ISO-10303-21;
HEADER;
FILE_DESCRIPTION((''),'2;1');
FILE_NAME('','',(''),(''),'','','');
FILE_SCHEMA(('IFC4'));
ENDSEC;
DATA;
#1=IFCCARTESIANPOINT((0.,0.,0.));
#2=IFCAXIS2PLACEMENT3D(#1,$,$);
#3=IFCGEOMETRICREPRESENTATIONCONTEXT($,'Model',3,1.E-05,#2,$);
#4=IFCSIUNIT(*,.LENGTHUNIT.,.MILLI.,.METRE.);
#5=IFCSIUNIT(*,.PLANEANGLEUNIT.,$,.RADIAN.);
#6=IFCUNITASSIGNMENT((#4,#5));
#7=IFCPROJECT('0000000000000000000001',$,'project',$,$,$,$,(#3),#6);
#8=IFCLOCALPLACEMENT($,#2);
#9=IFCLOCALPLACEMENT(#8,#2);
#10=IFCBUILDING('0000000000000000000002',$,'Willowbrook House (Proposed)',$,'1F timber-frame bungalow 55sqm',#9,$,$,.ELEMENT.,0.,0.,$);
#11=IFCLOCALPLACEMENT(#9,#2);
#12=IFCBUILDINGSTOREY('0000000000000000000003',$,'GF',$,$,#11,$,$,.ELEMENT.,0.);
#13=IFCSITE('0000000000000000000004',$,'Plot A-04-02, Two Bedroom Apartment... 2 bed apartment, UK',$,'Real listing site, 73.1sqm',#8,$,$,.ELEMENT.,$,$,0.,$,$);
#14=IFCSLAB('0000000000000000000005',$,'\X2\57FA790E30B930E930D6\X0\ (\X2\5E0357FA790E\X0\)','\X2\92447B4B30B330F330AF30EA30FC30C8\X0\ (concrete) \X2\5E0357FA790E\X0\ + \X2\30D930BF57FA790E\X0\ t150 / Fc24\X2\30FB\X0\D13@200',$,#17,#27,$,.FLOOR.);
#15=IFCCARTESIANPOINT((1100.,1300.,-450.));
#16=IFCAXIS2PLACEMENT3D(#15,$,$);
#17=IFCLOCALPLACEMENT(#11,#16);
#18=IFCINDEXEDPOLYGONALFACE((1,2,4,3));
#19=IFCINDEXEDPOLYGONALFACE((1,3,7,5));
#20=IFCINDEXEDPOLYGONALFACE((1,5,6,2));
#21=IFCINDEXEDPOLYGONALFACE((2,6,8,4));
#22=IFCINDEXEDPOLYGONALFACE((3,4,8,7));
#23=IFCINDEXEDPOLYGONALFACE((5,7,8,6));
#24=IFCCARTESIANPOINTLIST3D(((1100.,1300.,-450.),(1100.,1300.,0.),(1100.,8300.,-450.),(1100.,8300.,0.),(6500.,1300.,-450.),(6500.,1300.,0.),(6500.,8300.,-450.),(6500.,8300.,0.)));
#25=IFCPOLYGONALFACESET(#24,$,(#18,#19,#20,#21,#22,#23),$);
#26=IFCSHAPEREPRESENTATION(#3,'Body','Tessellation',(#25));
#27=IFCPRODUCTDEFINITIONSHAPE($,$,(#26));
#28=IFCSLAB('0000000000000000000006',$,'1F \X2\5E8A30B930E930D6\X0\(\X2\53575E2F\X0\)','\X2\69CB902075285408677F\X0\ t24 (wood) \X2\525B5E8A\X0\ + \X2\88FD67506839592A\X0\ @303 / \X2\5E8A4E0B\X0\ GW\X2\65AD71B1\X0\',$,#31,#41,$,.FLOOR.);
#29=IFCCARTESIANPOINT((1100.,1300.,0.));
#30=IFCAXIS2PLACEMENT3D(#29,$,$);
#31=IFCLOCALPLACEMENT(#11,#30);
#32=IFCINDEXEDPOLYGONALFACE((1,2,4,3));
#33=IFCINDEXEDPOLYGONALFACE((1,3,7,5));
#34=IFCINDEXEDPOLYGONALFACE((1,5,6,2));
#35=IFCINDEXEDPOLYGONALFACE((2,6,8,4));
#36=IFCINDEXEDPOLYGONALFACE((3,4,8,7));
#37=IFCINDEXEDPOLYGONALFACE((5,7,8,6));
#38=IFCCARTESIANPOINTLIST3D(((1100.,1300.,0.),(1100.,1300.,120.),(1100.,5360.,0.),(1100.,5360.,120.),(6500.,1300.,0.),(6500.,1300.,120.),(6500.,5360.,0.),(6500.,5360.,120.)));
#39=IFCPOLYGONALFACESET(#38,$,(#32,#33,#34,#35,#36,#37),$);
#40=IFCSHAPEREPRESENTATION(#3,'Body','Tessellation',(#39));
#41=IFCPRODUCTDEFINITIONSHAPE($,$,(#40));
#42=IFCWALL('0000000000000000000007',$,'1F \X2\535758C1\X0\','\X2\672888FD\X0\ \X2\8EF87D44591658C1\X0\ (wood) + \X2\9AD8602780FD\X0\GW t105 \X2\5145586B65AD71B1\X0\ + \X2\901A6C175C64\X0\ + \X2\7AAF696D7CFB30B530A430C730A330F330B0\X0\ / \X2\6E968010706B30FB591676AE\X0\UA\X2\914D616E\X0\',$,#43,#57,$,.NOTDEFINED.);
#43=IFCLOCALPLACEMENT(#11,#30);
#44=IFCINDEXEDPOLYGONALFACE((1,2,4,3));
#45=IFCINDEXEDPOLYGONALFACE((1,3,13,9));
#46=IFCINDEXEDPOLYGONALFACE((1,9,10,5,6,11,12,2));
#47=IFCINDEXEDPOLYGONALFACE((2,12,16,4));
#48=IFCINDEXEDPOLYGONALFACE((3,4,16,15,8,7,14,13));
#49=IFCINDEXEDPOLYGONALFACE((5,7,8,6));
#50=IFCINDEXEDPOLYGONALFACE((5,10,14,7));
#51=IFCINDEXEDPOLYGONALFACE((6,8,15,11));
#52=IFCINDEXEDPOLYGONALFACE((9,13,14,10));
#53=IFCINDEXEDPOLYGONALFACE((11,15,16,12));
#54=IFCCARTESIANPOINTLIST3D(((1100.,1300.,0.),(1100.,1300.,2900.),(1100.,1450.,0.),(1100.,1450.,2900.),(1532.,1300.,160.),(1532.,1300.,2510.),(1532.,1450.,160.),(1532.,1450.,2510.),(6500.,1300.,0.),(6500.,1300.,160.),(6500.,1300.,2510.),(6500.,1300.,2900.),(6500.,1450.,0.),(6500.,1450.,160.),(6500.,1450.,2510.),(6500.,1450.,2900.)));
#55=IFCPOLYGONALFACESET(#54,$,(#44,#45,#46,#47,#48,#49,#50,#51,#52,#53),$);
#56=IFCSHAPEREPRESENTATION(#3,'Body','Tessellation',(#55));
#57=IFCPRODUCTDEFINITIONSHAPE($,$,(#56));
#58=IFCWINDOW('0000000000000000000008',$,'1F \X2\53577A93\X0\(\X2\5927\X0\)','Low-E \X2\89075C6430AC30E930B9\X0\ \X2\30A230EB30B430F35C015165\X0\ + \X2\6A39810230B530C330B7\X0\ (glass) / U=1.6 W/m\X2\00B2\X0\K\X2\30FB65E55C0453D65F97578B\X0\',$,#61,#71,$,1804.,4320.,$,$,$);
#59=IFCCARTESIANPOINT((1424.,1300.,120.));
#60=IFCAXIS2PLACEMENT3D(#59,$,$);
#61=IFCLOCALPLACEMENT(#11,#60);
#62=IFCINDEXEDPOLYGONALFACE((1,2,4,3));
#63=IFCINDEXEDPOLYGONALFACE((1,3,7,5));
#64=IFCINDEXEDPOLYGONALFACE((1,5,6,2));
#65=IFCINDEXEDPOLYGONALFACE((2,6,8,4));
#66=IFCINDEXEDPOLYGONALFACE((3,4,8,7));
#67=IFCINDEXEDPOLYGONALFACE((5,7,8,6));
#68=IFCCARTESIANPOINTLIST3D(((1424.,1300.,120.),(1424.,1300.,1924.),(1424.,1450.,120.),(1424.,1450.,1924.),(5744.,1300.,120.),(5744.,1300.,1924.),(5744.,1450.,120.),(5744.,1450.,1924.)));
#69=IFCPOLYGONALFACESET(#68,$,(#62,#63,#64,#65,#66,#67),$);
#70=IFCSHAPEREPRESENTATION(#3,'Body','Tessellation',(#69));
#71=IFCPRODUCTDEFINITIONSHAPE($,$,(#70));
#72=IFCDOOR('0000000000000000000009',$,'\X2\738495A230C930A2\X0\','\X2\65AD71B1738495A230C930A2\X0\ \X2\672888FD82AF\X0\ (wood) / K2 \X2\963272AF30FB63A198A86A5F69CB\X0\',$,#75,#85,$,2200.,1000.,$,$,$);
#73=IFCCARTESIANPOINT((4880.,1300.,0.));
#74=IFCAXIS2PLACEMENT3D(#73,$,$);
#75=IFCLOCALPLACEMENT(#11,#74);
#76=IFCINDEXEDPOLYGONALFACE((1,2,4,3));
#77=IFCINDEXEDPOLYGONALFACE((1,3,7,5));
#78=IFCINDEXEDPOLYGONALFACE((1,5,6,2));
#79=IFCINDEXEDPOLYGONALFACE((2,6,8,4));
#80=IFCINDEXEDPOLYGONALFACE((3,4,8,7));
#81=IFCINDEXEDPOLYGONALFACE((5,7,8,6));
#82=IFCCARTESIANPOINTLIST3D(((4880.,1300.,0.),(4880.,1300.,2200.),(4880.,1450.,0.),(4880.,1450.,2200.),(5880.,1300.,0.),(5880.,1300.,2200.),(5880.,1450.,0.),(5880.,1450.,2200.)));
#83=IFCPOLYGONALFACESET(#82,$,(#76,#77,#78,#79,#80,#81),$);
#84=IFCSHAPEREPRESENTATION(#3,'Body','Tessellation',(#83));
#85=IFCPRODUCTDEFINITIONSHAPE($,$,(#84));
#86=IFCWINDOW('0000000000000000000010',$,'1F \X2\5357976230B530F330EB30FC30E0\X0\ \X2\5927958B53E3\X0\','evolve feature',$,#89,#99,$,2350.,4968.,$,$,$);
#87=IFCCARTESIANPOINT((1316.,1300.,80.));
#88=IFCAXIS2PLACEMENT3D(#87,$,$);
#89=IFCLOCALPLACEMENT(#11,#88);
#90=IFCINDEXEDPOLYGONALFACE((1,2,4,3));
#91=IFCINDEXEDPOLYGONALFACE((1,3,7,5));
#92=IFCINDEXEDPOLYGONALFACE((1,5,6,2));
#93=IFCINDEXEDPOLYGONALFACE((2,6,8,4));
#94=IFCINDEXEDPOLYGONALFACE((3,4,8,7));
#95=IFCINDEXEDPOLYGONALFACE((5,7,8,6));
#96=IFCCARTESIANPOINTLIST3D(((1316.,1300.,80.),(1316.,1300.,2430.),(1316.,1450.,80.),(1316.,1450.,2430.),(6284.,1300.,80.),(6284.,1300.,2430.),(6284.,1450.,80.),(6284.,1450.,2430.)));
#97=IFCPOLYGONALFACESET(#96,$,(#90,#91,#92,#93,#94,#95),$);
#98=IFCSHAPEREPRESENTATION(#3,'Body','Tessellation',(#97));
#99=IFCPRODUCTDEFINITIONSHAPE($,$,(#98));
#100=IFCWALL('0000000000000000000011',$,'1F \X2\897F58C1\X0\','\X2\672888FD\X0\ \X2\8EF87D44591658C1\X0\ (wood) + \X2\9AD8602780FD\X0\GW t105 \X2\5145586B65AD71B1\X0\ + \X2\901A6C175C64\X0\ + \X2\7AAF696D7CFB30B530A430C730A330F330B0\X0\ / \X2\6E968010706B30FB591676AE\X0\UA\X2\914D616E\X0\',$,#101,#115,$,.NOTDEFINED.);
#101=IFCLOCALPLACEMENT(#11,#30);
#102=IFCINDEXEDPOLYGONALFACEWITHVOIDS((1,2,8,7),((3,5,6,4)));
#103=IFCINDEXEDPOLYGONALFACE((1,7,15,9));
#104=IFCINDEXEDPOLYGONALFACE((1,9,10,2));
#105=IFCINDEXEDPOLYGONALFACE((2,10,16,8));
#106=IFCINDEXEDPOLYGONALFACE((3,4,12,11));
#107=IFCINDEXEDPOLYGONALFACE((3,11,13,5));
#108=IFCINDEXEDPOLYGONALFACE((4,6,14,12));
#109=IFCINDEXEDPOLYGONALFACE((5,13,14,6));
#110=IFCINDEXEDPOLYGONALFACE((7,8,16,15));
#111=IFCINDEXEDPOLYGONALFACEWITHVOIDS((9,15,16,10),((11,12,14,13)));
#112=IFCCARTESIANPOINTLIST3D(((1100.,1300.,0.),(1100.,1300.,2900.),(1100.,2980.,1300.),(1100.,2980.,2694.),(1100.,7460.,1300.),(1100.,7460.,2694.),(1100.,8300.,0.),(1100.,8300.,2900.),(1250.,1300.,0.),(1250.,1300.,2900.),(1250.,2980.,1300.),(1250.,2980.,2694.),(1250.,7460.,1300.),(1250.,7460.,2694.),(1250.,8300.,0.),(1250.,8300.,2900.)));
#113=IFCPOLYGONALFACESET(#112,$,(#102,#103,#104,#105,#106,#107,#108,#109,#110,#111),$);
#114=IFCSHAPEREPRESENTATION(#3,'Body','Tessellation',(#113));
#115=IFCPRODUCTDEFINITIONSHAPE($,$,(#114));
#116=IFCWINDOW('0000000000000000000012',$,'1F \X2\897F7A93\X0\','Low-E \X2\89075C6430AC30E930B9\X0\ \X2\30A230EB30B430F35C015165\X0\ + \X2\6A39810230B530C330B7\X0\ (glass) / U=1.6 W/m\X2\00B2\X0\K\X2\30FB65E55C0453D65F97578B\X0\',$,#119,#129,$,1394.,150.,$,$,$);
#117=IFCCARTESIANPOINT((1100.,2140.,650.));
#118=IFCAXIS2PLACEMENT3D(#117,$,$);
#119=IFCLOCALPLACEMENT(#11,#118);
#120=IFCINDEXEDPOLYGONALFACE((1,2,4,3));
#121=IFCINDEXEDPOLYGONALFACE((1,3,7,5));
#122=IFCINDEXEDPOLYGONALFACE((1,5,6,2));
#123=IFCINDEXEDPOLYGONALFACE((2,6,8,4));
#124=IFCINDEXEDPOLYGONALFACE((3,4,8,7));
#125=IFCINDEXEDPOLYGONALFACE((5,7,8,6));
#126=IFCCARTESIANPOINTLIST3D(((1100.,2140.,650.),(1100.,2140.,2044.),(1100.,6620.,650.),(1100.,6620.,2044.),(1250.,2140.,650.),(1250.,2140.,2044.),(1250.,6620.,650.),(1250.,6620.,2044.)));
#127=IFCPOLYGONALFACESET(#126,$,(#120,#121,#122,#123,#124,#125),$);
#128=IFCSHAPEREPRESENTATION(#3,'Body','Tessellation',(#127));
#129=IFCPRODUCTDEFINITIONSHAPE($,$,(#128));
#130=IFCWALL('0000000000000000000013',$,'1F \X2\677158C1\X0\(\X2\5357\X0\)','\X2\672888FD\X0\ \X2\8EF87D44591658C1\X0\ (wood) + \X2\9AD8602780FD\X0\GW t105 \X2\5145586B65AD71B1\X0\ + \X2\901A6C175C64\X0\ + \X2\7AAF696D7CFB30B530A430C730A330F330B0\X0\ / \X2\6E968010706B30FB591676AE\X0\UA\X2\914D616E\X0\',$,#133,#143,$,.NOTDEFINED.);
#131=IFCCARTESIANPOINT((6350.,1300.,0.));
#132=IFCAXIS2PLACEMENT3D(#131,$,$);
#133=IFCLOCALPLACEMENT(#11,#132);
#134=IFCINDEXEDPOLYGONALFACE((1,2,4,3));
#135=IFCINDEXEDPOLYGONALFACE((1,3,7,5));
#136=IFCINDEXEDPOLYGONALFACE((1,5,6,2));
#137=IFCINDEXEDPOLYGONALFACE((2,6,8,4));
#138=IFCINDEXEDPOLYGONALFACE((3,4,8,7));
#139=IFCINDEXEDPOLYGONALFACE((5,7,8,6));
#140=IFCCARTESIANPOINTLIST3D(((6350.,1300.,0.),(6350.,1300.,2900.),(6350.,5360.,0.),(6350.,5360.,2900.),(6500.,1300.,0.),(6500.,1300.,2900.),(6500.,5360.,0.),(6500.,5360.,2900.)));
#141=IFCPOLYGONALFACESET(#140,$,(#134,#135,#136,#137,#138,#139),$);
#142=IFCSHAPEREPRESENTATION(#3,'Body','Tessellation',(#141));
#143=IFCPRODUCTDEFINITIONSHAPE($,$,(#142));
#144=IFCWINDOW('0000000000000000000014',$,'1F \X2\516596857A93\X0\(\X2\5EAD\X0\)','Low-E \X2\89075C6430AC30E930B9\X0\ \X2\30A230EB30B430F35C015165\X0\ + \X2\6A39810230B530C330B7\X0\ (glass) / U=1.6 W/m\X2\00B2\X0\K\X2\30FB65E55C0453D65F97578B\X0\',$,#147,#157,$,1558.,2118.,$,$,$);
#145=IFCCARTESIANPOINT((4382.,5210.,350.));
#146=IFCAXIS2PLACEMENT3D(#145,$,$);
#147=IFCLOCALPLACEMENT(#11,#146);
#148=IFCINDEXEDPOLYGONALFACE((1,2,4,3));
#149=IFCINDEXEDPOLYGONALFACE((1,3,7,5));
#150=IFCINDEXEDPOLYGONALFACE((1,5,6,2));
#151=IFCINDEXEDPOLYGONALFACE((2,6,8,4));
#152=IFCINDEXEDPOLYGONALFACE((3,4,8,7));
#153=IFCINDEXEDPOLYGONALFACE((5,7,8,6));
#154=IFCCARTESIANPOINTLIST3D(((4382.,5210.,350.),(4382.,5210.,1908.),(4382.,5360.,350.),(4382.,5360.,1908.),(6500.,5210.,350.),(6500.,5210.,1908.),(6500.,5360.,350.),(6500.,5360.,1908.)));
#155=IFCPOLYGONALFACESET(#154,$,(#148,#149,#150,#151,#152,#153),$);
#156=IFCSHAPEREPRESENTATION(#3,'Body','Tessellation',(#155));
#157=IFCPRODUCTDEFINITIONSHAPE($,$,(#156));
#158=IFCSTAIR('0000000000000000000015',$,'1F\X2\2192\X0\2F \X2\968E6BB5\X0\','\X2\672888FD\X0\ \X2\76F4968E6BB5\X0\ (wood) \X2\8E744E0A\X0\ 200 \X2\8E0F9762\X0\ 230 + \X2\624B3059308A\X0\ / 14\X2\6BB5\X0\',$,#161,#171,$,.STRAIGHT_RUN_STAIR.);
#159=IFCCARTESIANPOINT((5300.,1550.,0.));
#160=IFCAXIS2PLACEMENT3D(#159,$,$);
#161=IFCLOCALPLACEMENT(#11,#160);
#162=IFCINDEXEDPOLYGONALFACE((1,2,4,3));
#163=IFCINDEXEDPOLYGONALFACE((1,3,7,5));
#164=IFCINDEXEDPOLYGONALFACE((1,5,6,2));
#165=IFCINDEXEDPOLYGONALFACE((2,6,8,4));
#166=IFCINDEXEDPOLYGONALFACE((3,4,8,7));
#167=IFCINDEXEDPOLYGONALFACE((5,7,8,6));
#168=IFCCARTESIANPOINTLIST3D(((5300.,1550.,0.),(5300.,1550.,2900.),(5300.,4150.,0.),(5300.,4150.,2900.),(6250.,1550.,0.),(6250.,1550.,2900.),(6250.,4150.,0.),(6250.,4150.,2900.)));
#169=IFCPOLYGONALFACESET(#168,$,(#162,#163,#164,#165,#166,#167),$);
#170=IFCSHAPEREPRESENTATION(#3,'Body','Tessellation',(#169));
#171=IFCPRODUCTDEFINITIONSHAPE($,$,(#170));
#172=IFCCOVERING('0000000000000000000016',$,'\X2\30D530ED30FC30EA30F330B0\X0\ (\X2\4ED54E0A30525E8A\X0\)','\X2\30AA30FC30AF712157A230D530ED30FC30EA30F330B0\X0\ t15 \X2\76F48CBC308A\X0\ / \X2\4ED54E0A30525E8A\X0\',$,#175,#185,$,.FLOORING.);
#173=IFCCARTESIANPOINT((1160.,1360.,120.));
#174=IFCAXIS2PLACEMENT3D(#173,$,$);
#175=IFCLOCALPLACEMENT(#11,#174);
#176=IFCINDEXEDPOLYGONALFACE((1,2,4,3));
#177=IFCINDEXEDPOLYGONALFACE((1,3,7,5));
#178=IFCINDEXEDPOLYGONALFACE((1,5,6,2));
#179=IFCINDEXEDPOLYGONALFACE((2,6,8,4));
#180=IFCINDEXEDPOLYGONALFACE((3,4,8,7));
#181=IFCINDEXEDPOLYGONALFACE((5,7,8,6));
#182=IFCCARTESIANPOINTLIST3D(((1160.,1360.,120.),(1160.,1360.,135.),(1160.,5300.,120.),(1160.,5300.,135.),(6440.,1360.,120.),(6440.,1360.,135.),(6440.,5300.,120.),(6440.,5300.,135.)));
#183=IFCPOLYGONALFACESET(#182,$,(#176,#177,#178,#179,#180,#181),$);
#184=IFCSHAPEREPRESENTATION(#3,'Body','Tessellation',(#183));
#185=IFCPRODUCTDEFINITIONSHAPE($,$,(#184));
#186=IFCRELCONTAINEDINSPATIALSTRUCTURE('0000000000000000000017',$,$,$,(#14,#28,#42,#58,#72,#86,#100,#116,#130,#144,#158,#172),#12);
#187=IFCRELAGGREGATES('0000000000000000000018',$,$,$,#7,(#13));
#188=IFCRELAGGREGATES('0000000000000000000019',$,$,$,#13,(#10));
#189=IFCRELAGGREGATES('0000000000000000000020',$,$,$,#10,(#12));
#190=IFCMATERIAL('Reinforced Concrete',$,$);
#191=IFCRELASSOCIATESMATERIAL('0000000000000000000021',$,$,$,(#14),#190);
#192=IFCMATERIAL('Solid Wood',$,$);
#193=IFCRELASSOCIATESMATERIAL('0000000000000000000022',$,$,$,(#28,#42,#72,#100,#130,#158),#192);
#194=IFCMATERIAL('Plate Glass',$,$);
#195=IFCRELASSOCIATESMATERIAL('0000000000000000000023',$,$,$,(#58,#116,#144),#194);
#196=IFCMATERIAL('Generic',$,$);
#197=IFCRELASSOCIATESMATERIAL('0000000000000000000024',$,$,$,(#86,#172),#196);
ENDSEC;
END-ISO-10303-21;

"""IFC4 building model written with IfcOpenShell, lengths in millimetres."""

from ifc_helpers import new_model, si_unit, frame, frame_2d, origin, place, context, project, spatial, rectangle, extrude, material, element, fill, save


model = new_model("IFC4")

# Units and contexts
model_context = context("Model", 3, precision=1e-05, world=origin())
ifc_project = project(units=[si_unit("LENGTHUNIT", "METRE", prefix="MILLI"), si_unit("PLANEANGLEUNIT", "RADIAN")], contexts=[model_context])

# Site, building, storey
site_placement = place(None, origin())
site = spatial("IfcSite", under=ifc_project, at=site_placement, Name="Plot A-04-02, Two Bedroom Apartment... 2 bed apartment, UK", ObjectType="Real listing site, 73.1sqm", CompositionType="ELEMENT", RefElevation=0.0)
building_placement = place(site_placement, origin())
building = spatial("IfcBuilding", under=site, at=building_placement, Name="Willowbrook House (Proposed)", ObjectType="1F timber-frame bungalow 55sqm", CompositionType="ELEMENT", ElevationOfRefHeight=0.0, ElevationOfTerrain=0.0)
storey_placement = place(building_placement, origin())
storey = spatial("IfcBuildingStorey", under=building, at=storey_placement, Name="GF", CompositionType="ELEMENT", Elevation=0.0)

# Slabs
ifc_material_1 = material(Name="Reinforced Concrete")
slab_1_placement = place(storey_placement, frame((1100.0, 1300.0, -450.0)))
element("IfcSlab", 1, at=slab_1_placement, inside=storey, material=ifc_material_1, Name="基礎スラブ (布基礎)", Description="鉄筋コンクリート (concrete) 布基礎 + ベタ基礎 t150 / Fc24・D13@200", PredefinedType="FLOOR", context=model_context, shape_type="SweptSolid", body=[
    extrude(rectangle(XDim=5400.0, YDim=7000.0, at=frame_2d((2700.0, 3500.0))), frame((1100.0, 1300.0, -450.0)), (0.0, 0.0, 1.0), 450.0),
])
ifc_material_2 = material(Name="Solid Wood")
slab_2_placement = place(storey_placement, frame((1100.0, 1300.0, 0.0)))
element("IfcSlab", 2, at=slab_2_placement, inside=storey, material=ifc_material_2, Name="1F 床スラブ(南帯)", Description="構造用合板 t24 (wood) 剛床 + 製材根太 @303 / 床下 GW断熱", PredefinedType="FLOOR", context=model_context, shape_type="SweptSolid", body=[
    extrude(rectangle(XDim=5400.0, YDim=4060.0, at=frame_2d((2700.0, 2030.0))), frame((1100.0, 1300.0, 0.0)), (0.0, 0.0, 1.0), 120.0),
])

# Wall, openings, windows, door
wall_1_placement = place(storey_placement, frame((1100.0, 1300.0, 0.0)))
wall_1 = element("IfcWall", 3, at=wall_1_placement, inside=storey, material=ifc_material_2, Name="1F 南壁", Description="木製 軸組外壁 (wood) + 高性能GW t105 充填断熱 + 通気層 + 窯業系サイディング / 準耐火・外皮UA配慮", PredefinedType="NOTDEFINED", context=model_context, shape_type="SweptSolid", body=[
    extrude(rectangle(XDim=5400.0, YDim=150.0, at=frame_2d((2700.0, 75.0))), frame((1100.0, 1300.0, 0.0)), (0.0, 0.0, 1.0), 2900.0),
])
opening_1_placement = place(storey_placement, frame((1424.0, 1300.0, 120.0)))
opening_1 = element("IfcOpeningElement", 4, at=opening_1_placement, cuts=wall_1, PredefinedType="NOTDEFINED", context=model_context, shape_type="SweptSolid", body=[
    extrude(rectangle(XDim=4320.0, YDim=150.0, at=frame_2d((2160.0, 75.0))), frame((1424.0, 1300.0, 120.0)), (0.0, 0.0, 1.0), 1804.0),
])
opening_2_placement = place(storey_placement, frame((4880.0, 1300.0, 0.0)))
opening_2 = element("IfcOpeningElement", 5, at=opening_2_placement, cuts=wall_1, PredefinedType="NOTDEFINED", context=model_context, shape_type="SweptSolid", body=[
    extrude(rectangle(XDim=1000.0, YDim=150.0, at=frame_2d((500.0, 75.0))), frame((4880.0, 1300.0, 0.0)), (0.0, 0.0, 1.0), 2200.0),
])
opening_3_placement = place(storey_placement, frame((1316.0, 1300.0, 80.0)))
opening_3 = element("IfcOpeningElement", 6, at=opening_3_placement, cuts=wall_1, PredefinedType="NOTDEFINED", context=model_context, shape_type="SweptSolid", body=[
    extrude(rectangle(XDim=4968.0, YDim=150.0, at=frame_2d((2484.0, 75.0))), frame((1316.0, 1300.0, 80.0)), (0.0, 0.0, 1.0), 2350.0),
])
ifc_material_3 = material(Name="Plate Glass")
window_1_placement = place(storey_placement, frame((1424.0, 1300.0, 120.0)))
window_1 = element("IfcWindow", 7, at=window_1_placement, inside=storey, material=ifc_material_3, Name="1F 南窓(大)", Description="Low-E 複層ガラス アルゴン封入 + 樹脂サッシ (glass) / U=1.6 W/m²K・日射取得型", OverallHeight=1804.0, OverallWidth=4320.0, context=model_context, shape_type="SweptSolid", body=[
    extrude(rectangle(XDim=4320.0, YDim=150.0, at=frame_2d((2160.0, 75.0))), frame((1424.0, 1300.0, 120.0)), (0.0, 0.0, 1.0), 1804.0),
])
fill(opening_1, window_1)
door_1_placement = place(storey_placement, frame((4880.0, 1300.0, 0.0)))
door_1 = element("IfcDoor", 8, at=door_1_placement, inside=storey, material=ifc_material_2, Name="玄関ドア", Description="断熱玄関ドア 木製芯 (wood) / K2 防犯・採風機構", OverallHeight=2200.0, OverallWidth=1000.0, context=model_context, shape_type="SweptSolid", body=[
    extrude(rectangle(XDim=1000.0, YDim=150.0, at=frame_2d((500.0, 75.0))), frame((4880.0, 1300.0, 0.0)), (0.0, 0.0, 1.0), 2200.0),
])
fill(opening_2, door_1)
ifc_material_4 = material(Name="Generic")
window_2_placement = place(storey_placement, frame((1316.0, 1300.0, 80.0)))
window_2 = element("IfcWindow", 9, at=window_2_placement, inside=storey, material=ifc_material_4, Name="1F 南面サンルーム 大開口", Description="evolve feature", OverallHeight=2350.0, OverallWidth=4968.0, context=model_context, shape_type="SweptSolid", body=[
    extrude(rectangle(XDim=4968.0, YDim=150.0, at=frame_2d((2484.0, 75.0))), frame((1316.0, 1300.0, 80.0)), (0.0, 0.0, 1.0), 2350.0),
])
fill(opening_3, window_2)

# Walls, openings, windows
wall_2_placement = place(storey_placement, frame((1100.0, 1300.0, 0.0)))
wall_2 = element("IfcWall", 10, at=wall_2_placement, inside=storey, material=ifc_material_2, Name="1F 西壁", Description="木製 軸組外壁 (wood) + 高性能GW t105 充填断熱 + 通気層 + 窯業系サイディング / 準耐火・外皮UA配慮", PredefinedType="NOTDEFINED", context=model_context, shape_type="SweptSolid", body=[
    extrude(rectangle(XDim=150.0, YDim=7000.0, at=frame_2d((75.0, 3500.0))), frame((1100.0, 1300.0, 0.0)), (0.0, 0.0, 1.0), 2900.0),
])
opening_4_placement = place(storey_placement, frame((1100.0, 2140.0, 650.0)))
opening_4 = element("IfcOpeningElement", 11, at=opening_4_placement, cuts=wall_2, PredefinedType="NOTDEFINED", context=model_context, shape_type="SweptSolid", body=[
    extrude(rectangle(XDim=150.0, YDim=4480.0, at=frame_2d((75.0, 2240.0))), frame((1100.0, 2140.0, 650.0)), (0.0, 0.0, 1.0), 1394.0),
])
window_3_placement = place(storey_placement, frame((1100.0, 2140.0, 650.0)))
window_3 = element("IfcWindow", 12, at=window_3_placement, inside=storey, material=ifc_material_3, Name="1F 西窓", Description="Low-E 複層ガラス アルゴン封入 + 樹脂サッシ (glass) / U=1.6 W/m²K・日射取得型", OverallHeight=1394.0, OverallWidth=150.0, context=model_context, shape_type="SweptSolid", body=[
    extrude(rectangle(XDim=150.0, YDim=4480.0, at=frame_2d((75.0, 2240.0))), frame((1100.0, 2140.0, 650.0)), (0.0, 0.0, 1.0), 1394.0),
])
fill(opening_4, window_3)
wall_3_placement = place(storey_placement, frame((6350.0, 1300.0, 0.0)))
wall_3 = element("IfcWall", 13, at=wall_3_placement, inside=storey, material=ifc_material_2, Name="1F 東壁(南)", Description="木製 軸組外壁 (wood) + 高性能GW t105 充填断熱 + 通気層 + 窯業系サイディング / 準耐火・外皮UA配慮", PredefinedType="NOTDEFINED", context=model_context, shape_type="SweptSolid", body=[
    extrude(rectangle(XDim=150.0, YDim=4060.0, at=frame_2d((75.0, 2030.0))), frame((6350.0, 1300.0, 0.0)), (0.0, 0.0, 1.0), 2900.0),
])
opening_5_placement = place(storey_placement, frame((4382.0, 5210.0, 350.0)))
opening_5 = element("IfcOpeningElement", 14, at=opening_5_placement, cuts=wall_3, PredefinedType="NOTDEFINED", context=model_context, shape_type="SweptSolid", body=[
    extrude(rectangle(XDim=2118.0, YDim=150.0, at=frame_2d((1059.0, 75.0))), frame((4382.0, 5210.0, 350.0)), (0.0, 0.0, 1.0), 1558.0),
])
window_4_placement = place(storey_placement, frame((4382.0, 5210.0, 350.0)))
window_4 = element("IfcWindow", 15, at=window_4_placement, inside=storey, material=ifc_material_3, Name="1F 入隅窓(庭)", Description="Low-E 複層ガラス アルゴン封入 + 樹脂サッシ (glass) / U=1.6 W/m²K・日射取得型", OverallHeight=1558.0, OverallWidth=2118.0, context=model_context, shape_type="SweptSolid", body=[
    extrude(rectangle(XDim=2118.0, YDim=150.0, at=frame_2d((1059.0, 75.0))), frame((4382.0, 5210.0, 350.0)), (0.0, 0.0, 1.0), 1558.0),
])
fill(opening_5, window_4)

# Stair
stair_placement = place(storey_placement, frame((5300.0, 1550.0, 0.0)))
element("IfcStair", 16, at=stair_placement, inside=storey, material=ifc_material_2, Name="1F→2F 階段", Description="木製 直階段 (wood) 蹴上 200 踏面 230 + 手すり / 14段", PredefinedType="STRAIGHT_RUN_STAIR", context=model_context, shape_type="SweptSolid", body=[
    extrude(rectangle(XDim=950.0, YDim=2600.0, at=frame_2d((475.0, 1300.0))), frame((5300.0, 1550.0, 0.0)), (0.0, 0.0, 1.0), 2900.0),
])

# Covering
covering_placement = place(storey_placement, frame((1160.0, 1360.0, 120.0)))
element("IfcCovering", 17, at=covering_placement, inside=storey, material=ifc_material_4, Name="フローリング (仕上げ床)", Description="オーク無垢フローリング t15 直貼り / 仕上げ床", PredefinedType="FLOORING", context=model_context, shape_type="SweptSolid", body=[
    extrude(rectangle(XDim=5280.0, YDim=3940.0, at=frame_2d((2640.0, 1970.0))), frame((1160.0, 1360.0, 120.0)), (0.0, 0.0, 1.0), 15.0),
])

save(model, "model.ifc")
